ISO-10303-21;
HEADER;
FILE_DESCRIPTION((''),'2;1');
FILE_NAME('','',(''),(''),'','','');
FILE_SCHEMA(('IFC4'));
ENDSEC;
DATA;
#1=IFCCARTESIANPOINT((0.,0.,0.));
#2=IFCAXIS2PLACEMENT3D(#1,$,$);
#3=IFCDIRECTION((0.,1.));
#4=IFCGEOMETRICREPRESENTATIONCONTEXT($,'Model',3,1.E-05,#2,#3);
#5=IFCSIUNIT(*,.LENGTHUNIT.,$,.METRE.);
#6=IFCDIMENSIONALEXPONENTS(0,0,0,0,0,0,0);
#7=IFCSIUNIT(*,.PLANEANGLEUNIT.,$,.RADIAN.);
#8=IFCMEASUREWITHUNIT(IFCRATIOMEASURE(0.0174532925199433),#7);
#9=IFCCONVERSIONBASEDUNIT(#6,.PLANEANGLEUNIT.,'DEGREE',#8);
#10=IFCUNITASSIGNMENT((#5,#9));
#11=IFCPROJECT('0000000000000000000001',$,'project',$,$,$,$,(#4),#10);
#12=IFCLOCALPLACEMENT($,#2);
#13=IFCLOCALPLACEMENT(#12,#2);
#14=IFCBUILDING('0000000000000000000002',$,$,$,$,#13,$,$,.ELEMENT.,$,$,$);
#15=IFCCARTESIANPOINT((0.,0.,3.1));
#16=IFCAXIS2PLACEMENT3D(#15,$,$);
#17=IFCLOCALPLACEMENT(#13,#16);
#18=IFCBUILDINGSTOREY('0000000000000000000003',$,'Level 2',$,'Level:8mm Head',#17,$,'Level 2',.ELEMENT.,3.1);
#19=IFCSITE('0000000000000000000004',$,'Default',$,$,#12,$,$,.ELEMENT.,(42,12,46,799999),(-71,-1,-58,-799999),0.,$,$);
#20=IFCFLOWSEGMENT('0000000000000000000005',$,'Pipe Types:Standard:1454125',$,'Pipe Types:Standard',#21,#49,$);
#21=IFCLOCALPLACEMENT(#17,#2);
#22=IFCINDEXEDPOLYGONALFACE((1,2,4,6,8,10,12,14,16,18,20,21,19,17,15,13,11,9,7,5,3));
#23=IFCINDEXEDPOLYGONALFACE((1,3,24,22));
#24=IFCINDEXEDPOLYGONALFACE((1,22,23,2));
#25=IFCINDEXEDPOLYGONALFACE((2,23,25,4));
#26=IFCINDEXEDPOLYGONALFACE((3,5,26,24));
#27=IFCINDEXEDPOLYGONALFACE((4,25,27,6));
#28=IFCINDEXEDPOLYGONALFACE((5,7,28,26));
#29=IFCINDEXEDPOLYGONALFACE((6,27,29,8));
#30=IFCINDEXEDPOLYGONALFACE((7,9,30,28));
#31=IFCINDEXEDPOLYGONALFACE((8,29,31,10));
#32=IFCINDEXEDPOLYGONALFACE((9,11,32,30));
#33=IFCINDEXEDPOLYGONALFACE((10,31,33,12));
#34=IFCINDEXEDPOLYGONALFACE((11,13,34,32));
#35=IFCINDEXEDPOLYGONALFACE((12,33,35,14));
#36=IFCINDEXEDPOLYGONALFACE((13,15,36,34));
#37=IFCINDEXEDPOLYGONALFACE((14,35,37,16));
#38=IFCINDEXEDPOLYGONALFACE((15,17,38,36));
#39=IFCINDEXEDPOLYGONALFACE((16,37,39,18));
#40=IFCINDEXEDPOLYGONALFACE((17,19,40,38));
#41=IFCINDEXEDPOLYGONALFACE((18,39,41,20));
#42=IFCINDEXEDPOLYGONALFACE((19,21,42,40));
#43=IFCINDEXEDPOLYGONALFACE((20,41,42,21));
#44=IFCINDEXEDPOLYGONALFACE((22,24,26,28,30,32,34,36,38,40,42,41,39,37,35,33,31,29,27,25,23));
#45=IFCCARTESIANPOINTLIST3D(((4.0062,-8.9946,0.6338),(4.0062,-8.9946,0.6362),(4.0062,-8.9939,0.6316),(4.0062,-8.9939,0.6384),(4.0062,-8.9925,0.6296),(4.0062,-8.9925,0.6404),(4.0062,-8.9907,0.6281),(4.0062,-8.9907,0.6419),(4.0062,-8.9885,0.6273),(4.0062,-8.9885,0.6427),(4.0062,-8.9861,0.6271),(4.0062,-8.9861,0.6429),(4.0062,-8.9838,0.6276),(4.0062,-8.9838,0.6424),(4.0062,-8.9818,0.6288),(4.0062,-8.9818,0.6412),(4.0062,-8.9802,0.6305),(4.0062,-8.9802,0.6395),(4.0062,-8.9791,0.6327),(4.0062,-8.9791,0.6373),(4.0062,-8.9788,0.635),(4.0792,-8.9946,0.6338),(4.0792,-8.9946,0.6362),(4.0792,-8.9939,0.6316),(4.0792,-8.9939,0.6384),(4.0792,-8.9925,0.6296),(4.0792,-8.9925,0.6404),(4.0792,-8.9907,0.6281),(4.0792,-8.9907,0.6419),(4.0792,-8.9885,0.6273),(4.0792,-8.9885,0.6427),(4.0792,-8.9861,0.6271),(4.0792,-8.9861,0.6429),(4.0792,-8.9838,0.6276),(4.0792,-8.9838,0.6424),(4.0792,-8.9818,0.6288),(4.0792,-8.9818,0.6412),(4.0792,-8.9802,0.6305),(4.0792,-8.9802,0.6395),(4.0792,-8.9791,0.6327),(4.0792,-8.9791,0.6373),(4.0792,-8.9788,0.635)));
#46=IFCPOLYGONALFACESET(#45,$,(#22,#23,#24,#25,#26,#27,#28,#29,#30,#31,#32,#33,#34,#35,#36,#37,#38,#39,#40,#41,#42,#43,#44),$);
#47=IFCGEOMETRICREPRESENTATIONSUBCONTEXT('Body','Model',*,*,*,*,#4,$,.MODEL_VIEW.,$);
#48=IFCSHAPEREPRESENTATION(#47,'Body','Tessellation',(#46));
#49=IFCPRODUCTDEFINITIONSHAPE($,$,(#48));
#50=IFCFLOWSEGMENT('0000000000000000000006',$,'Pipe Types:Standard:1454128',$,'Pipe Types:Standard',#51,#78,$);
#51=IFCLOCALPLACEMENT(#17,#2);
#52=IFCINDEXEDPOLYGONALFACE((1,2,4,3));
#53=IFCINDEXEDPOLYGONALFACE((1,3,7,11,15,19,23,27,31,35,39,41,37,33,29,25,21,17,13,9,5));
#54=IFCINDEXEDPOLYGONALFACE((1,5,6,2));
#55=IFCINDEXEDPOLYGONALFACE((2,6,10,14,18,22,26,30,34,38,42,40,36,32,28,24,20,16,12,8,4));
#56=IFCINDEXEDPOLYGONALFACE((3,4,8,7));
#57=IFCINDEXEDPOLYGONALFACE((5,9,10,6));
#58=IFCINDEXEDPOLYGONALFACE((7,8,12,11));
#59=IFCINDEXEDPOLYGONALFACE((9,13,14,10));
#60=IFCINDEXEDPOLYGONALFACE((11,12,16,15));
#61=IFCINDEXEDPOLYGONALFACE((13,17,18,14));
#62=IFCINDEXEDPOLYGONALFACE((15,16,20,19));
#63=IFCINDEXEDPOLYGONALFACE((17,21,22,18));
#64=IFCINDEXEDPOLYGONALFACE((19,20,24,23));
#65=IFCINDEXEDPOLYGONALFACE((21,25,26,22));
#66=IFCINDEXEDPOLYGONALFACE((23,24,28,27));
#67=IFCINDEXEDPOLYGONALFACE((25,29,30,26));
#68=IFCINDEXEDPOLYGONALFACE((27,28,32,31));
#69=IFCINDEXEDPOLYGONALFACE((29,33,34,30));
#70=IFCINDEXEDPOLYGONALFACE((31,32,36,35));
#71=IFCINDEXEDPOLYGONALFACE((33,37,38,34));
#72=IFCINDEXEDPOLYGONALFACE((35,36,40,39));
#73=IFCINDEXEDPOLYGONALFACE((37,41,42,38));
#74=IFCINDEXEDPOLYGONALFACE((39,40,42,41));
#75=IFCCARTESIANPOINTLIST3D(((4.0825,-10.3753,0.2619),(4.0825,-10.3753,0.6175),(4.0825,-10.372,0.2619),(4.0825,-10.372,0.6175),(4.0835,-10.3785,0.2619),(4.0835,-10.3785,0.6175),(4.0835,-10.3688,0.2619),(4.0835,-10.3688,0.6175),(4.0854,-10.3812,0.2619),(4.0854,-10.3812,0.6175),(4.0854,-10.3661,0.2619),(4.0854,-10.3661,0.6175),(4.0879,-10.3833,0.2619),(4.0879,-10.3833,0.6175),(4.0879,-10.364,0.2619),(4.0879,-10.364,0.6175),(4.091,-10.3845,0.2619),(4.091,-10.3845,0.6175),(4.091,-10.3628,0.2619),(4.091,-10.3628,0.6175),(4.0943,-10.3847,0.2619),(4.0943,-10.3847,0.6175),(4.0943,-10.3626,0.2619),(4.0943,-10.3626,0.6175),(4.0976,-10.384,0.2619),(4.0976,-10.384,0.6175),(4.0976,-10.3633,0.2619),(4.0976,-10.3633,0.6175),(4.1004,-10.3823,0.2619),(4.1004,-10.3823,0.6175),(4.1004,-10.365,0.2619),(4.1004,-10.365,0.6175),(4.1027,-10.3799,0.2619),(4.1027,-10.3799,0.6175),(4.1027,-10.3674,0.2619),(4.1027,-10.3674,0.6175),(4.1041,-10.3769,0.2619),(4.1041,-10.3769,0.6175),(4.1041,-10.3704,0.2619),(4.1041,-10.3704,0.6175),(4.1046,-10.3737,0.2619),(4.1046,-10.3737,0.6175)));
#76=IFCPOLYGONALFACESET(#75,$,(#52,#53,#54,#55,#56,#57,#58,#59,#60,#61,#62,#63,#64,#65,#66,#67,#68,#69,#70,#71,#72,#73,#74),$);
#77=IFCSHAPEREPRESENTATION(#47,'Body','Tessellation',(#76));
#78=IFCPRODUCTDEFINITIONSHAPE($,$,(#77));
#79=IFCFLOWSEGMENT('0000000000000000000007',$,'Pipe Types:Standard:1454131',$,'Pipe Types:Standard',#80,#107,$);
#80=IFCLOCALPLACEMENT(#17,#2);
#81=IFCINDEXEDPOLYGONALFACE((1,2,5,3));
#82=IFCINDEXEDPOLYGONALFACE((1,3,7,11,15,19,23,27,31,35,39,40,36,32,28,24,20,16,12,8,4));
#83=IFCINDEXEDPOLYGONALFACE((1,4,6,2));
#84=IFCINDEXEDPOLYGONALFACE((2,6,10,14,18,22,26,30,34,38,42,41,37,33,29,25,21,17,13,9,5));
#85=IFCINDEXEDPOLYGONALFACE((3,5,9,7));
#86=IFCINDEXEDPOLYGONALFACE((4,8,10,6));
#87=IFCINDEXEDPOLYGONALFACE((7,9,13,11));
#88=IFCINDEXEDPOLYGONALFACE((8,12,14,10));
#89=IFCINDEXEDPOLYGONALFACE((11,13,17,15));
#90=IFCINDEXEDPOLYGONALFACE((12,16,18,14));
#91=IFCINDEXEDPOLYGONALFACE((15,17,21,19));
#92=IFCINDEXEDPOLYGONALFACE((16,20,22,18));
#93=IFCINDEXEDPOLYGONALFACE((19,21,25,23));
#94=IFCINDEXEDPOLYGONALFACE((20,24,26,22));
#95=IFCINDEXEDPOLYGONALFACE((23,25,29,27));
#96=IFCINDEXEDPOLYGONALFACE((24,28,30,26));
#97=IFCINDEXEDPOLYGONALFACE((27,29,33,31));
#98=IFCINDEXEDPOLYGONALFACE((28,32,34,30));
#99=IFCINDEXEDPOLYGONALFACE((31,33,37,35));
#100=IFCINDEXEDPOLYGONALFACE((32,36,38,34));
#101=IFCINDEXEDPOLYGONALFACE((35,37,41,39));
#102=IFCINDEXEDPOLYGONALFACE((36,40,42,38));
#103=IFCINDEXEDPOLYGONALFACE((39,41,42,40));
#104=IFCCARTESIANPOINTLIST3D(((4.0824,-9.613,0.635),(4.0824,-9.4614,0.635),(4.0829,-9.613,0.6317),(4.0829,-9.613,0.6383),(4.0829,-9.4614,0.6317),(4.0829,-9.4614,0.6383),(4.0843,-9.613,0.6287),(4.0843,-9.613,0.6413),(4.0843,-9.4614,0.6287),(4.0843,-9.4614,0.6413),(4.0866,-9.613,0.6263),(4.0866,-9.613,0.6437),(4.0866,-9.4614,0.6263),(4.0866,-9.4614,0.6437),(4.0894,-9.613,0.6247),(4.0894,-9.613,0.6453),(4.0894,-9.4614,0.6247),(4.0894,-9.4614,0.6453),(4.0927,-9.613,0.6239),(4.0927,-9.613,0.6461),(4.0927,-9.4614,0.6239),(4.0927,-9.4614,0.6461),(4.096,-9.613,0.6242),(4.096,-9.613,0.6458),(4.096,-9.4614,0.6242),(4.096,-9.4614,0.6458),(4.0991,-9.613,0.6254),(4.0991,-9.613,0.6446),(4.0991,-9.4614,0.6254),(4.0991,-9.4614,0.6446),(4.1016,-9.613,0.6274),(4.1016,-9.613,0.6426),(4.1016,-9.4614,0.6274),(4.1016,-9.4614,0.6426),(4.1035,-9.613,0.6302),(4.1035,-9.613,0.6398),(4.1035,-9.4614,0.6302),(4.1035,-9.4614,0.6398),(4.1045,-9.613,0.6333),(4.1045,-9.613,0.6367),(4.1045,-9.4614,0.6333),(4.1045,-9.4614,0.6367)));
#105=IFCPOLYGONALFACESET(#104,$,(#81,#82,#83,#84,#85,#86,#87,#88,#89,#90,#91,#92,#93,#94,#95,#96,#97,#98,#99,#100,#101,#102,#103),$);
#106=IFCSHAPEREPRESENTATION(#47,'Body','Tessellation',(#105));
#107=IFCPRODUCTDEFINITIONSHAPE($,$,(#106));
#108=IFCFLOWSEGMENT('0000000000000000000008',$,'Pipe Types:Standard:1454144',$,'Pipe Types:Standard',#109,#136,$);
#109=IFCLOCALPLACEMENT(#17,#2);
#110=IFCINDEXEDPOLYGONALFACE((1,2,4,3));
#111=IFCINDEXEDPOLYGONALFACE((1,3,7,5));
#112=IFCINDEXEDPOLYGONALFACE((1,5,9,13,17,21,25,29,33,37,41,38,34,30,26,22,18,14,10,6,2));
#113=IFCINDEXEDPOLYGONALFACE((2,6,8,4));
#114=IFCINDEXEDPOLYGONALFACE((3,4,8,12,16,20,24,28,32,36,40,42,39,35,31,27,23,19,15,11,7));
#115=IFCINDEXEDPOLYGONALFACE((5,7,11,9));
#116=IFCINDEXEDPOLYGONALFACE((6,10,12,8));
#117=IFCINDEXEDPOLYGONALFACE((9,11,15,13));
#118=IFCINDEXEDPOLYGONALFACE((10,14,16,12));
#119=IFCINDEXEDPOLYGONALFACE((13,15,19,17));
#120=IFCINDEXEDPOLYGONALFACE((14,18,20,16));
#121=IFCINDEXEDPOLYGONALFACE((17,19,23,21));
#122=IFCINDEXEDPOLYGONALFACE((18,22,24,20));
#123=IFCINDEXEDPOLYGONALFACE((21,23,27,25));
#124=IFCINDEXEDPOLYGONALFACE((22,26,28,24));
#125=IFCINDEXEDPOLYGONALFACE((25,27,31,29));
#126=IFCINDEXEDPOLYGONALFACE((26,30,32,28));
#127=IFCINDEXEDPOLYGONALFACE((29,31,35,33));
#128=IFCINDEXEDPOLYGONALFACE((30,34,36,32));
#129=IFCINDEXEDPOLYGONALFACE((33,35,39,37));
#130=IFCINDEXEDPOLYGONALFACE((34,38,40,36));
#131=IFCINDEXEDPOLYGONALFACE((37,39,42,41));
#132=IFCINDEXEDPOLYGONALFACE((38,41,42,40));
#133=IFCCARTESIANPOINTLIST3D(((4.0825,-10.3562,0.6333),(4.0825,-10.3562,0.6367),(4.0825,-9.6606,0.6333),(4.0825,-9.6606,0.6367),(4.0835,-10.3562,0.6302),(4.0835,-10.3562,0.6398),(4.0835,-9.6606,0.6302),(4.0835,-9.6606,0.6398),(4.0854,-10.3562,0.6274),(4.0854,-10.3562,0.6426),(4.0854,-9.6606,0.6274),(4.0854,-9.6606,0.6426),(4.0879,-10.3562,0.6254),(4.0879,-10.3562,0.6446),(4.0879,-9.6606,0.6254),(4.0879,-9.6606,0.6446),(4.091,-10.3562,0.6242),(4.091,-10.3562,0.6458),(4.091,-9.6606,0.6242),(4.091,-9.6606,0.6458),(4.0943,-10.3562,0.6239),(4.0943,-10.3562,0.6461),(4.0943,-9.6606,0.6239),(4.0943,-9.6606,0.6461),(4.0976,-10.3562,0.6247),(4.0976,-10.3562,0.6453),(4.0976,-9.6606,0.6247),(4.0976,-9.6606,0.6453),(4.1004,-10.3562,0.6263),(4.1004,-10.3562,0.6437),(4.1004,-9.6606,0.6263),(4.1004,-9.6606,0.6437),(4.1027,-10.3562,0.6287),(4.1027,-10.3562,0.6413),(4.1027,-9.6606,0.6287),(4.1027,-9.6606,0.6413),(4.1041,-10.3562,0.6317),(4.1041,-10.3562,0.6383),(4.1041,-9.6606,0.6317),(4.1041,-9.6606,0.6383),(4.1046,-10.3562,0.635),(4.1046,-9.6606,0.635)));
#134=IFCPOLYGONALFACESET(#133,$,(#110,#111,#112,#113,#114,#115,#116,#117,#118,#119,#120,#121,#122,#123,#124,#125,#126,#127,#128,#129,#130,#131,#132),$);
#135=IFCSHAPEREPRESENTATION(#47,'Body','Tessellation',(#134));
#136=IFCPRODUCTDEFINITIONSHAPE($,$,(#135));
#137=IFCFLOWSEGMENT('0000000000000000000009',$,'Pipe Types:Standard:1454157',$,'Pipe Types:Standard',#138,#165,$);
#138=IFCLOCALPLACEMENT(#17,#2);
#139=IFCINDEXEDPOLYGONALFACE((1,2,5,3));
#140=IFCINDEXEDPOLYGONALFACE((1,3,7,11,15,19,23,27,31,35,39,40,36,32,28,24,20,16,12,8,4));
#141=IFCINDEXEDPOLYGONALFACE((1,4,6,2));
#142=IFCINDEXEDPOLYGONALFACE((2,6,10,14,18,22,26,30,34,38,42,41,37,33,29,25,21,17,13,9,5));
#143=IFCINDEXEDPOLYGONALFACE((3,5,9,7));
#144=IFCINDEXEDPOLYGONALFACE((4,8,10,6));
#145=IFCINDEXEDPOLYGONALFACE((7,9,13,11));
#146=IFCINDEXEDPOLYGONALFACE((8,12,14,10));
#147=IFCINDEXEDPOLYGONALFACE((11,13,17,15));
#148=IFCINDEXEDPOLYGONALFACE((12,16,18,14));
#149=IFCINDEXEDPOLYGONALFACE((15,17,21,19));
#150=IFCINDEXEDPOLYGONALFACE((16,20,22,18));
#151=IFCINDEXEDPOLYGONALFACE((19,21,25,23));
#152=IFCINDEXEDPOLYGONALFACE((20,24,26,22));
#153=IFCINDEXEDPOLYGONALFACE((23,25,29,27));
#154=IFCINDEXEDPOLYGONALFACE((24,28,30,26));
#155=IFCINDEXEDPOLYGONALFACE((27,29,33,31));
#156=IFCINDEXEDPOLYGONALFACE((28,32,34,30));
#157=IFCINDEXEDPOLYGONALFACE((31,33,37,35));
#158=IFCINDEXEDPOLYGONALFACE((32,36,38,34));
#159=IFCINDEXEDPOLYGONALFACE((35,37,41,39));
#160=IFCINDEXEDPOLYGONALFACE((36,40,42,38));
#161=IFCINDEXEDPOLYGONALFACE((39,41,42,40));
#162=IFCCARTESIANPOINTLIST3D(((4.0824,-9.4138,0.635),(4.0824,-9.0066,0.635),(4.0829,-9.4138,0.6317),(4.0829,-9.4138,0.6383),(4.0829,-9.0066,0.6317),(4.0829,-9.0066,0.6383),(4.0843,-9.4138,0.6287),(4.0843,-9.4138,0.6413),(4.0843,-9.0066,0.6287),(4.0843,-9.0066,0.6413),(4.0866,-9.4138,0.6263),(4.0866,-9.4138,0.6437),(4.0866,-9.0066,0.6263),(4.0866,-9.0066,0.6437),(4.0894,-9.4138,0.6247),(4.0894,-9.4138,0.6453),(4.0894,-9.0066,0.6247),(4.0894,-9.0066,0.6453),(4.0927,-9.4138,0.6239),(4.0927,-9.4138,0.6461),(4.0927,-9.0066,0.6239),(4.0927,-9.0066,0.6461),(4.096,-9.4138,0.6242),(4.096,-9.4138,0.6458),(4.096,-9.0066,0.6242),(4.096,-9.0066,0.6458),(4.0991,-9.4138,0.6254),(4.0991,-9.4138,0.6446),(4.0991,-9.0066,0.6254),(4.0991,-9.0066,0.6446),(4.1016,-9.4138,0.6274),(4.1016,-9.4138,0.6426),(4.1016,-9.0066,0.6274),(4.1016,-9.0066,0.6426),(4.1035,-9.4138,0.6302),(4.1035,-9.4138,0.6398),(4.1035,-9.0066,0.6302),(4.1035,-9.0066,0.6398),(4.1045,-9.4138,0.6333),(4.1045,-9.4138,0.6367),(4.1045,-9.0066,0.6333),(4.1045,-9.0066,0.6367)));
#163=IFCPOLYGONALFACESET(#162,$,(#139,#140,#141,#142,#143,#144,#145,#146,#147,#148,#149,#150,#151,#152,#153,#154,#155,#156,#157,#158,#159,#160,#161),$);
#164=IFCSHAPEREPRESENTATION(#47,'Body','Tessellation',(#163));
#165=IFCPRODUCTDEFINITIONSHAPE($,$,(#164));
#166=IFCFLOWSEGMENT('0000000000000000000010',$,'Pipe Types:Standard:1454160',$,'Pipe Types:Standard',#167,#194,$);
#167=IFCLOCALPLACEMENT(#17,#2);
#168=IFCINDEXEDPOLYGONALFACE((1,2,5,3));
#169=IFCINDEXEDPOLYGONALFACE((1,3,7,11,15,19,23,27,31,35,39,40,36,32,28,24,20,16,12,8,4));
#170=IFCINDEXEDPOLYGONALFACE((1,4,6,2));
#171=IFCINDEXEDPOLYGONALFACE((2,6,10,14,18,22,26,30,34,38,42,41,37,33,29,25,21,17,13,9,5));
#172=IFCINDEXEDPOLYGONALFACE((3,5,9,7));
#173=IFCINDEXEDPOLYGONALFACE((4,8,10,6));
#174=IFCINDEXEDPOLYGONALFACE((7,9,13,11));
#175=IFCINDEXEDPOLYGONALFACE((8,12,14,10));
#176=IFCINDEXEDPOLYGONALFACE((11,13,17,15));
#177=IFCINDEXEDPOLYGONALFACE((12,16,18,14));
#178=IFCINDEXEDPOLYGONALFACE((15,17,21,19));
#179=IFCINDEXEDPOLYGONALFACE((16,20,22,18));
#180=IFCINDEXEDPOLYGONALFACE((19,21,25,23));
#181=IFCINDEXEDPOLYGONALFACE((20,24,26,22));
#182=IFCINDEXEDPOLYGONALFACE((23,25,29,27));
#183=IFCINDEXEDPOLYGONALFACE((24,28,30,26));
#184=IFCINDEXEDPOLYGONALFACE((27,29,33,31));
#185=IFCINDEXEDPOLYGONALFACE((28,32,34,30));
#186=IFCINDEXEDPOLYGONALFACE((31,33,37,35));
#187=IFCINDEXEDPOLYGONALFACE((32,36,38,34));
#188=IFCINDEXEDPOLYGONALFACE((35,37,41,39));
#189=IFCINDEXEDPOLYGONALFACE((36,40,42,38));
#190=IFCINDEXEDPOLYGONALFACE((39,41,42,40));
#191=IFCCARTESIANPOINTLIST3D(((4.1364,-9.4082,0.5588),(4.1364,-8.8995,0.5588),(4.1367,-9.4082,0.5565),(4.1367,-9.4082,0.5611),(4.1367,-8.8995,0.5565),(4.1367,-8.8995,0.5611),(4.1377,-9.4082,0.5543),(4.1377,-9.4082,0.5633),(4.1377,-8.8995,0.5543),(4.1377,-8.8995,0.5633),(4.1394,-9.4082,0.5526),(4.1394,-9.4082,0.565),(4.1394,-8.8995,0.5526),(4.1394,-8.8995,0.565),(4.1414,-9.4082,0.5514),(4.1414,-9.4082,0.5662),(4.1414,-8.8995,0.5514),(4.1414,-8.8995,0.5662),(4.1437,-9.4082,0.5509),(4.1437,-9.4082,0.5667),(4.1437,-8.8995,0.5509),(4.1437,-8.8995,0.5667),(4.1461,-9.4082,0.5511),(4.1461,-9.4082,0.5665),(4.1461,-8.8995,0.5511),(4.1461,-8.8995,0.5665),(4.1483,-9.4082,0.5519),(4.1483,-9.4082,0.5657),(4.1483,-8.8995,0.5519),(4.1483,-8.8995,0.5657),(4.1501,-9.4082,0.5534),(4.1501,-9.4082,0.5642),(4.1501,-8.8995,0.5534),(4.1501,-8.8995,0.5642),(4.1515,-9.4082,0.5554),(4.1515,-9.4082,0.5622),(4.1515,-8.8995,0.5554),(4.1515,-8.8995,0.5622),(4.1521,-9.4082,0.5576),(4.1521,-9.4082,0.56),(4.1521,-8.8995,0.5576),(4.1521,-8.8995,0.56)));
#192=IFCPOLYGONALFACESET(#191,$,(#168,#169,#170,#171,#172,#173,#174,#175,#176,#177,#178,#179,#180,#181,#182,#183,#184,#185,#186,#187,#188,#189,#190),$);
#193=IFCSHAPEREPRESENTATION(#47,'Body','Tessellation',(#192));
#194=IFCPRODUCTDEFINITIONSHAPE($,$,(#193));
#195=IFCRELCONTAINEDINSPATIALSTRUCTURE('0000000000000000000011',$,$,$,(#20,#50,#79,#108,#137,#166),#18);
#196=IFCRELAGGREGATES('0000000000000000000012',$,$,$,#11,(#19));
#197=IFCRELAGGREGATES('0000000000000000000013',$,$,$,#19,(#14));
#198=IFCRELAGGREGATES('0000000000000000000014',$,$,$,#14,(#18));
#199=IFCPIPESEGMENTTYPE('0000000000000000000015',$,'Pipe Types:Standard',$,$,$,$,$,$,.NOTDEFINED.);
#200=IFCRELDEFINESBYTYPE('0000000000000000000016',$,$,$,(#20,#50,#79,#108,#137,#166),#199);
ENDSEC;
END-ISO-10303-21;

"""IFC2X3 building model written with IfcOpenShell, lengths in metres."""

from ifc_helpers import new_model, entity, si_unit, converted_unit, direction, frame, frame_2d, origin, origin_2d_with_axis, place, context, subcontext, project, spatial, circle, extrude, type_object, element, save


model = new_model("IFC2X3")

# Units and contexts
model_context = context("Model", 3, precision=1e-05, world=origin(), true_north=direction((0.0, 1.0)))
body_context = subcontext(model_context, "Body", "Model", "MODEL_VIEW")
ifc_project = project(units=[si_unit("LENGTHUNIT", "METRE"), converted_unit("PLANEANGLEUNIT", "DEGREE", entity("IfcRatioMeasure", 0.0174532925199433), si_unit("PLANEANGLEUNIT", "RADIAN"), dimensions=[0, 0, 0, 0, 0, 0, 0])], contexts=[model_context])

# Site, building, storey
site_placement = place(None, origin())
site = spatial("IfcSite", under=ifc_project, at=site_placement, Name="Default", CompositionType="ELEMENT", RefLatitude=(42, 12, 46, 799999), RefLongitude=(-71, -1, -58, -799999), RefElevation=0.0)
building_placement = place(site_placement, origin())
building = spatial("IfcBuilding", under=site, at=building_placement, CompositionType="ELEMENT")
storey_placement = place(building_placement, frame((0.0, 0.0, 3.1)))
storey = spatial("IfcBuildingStorey", under=building, at=storey_placement, Name="Level 2", ObjectType="Level:8mm Head", LongName="Level 2", CompositionType="ELEMENT", Elevation=3.1)

# Flow segments
pipe_segment_type = type_object("IfcPipeSegmentType", Name="Pipe Types:Standard", PredefinedType="NOTDEFINED")
flow_segment_1_placement = place(storey_placement, origin())
element("IfcFlowSegment", 1, at=flow_segment_1_placement, inside=storey, type_object=pipe_segment_type, Name="Pipe Types:Standard:1454125", ObjectType="Pipe Types:Standard", context=body_context, shape_type="SweptSolid", body=[
    extrude(circle(Radius=0.0079, at=frame_2d((0.0, 0.0), x_axis=(1.0, 0.0))), frame((4.0062, -8.9867, 0.635), z_axis=(1.0, 0.0, 0.0), x_axis=(0.0, 1.0, 0.0)), (0.0, 0.0, 1.0), 0.073),
])
flow_segment_2_placement = place(storey_placement, origin())
element("IfcFlowSegment", 2, at=flow_segment_2_placement, inside=storey, type_object=pipe_segment_type, Name="Pipe Types:Standard:1454128", ObjectType="Pipe Types:Standard", context=body_context, shape_type="SweptSolid", body=[
    extrude(circle(Radius=0.0111, at=origin_2d_with_axis()), frame((4.0935, -10.3737, 0.2619)), (0.0, 0.0, 1.0), 0.3557),
])
flow_segment_3_placement = place(storey_placement, origin())
element("IfcFlowSegment", 3, at=flow_segment_3_placement, inside=storey, type_object=pipe_segment_type, Name="Pipe Types:Standard:1454131", ObjectType="Pipe Types:Standard", context=body_context, shape_type="SweptSolid", body=[
    extrude(circle(Radius=0.0111, at=frame_2d((0.0, 0.0), x_axis=(1.0, 0.0))), frame((4.0935, -9.613, 0.635), z_axis=(0.0, 1.0, 0.0), x_axis=(-1.0, 0.0, 0.0)), (0.0, 0.0, 1.0), 0.1515),
])
flow_segment_4_placement = place(storey_placement, origin())
element("IfcFlowSegment", 4, at=flow_segment_4_placement, inside=storey, type_object=pipe_segment_type, Name="Pipe Types:Standard:1454144", ObjectType="Pipe Types:Standard", context=body_context, shape_type="SweptSolid", body=[
    extrude(circle(Radius=0.0111, at=frame_2d((0.0, 0.0), x_axis=(1.0, 0.0))), frame((4.0935, -10.3562, 0.635), z_axis=(0.0, 1.0, 0.0), x_axis=(1.0, 0.0, 0.0)), (0.0, 0.0, 1.0), 0.6956),
])
flow_segment_5_placement = place(storey_placement, origin())
element("IfcFlowSegment", 5, at=flow_segment_5_placement, inside=storey, type_object=pipe_segment_type, Name="Pipe Types:Standard:1454157", ObjectType="Pipe Types:Standard", context=body_context, shape_type="SweptSolid", body=[
    extrude(circle(Radius=0.0111, at=frame_2d((0.0, 0.0), x_axis=(1.0, 0.0))), frame((4.0935, -9.4138, 0.635), z_axis=(0.0, 1.0, 0.0), x_axis=(-1.0, 0.0, 0.0)), (0.0, 0.0, 1.0), 0.4072),
])
flow_segment_6_placement = place(storey_placement, origin())
element("IfcFlowSegment", 6, at=flow_segment_6_placement, inside=storey, type_object=pipe_segment_type, Name="Pipe Types:Standard:1454160", ObjectType="Pipe Types:Standard", context=body_context, shape_type="SweptSolid", body=[
    extrude(circle(Radius=0.0079, at=frame_2d((0.0, 0.0), x_axis=(1.0, 0.0))), frame((4.1443, -9.4082, 0.5588), z_axis=(0.0, 1.0, 0.0), x_axis=(-1.0, 0.0, 0.0)), (0.0, 0.0, 1.0), 0.5088),
])

save(model, "model.ifc")
